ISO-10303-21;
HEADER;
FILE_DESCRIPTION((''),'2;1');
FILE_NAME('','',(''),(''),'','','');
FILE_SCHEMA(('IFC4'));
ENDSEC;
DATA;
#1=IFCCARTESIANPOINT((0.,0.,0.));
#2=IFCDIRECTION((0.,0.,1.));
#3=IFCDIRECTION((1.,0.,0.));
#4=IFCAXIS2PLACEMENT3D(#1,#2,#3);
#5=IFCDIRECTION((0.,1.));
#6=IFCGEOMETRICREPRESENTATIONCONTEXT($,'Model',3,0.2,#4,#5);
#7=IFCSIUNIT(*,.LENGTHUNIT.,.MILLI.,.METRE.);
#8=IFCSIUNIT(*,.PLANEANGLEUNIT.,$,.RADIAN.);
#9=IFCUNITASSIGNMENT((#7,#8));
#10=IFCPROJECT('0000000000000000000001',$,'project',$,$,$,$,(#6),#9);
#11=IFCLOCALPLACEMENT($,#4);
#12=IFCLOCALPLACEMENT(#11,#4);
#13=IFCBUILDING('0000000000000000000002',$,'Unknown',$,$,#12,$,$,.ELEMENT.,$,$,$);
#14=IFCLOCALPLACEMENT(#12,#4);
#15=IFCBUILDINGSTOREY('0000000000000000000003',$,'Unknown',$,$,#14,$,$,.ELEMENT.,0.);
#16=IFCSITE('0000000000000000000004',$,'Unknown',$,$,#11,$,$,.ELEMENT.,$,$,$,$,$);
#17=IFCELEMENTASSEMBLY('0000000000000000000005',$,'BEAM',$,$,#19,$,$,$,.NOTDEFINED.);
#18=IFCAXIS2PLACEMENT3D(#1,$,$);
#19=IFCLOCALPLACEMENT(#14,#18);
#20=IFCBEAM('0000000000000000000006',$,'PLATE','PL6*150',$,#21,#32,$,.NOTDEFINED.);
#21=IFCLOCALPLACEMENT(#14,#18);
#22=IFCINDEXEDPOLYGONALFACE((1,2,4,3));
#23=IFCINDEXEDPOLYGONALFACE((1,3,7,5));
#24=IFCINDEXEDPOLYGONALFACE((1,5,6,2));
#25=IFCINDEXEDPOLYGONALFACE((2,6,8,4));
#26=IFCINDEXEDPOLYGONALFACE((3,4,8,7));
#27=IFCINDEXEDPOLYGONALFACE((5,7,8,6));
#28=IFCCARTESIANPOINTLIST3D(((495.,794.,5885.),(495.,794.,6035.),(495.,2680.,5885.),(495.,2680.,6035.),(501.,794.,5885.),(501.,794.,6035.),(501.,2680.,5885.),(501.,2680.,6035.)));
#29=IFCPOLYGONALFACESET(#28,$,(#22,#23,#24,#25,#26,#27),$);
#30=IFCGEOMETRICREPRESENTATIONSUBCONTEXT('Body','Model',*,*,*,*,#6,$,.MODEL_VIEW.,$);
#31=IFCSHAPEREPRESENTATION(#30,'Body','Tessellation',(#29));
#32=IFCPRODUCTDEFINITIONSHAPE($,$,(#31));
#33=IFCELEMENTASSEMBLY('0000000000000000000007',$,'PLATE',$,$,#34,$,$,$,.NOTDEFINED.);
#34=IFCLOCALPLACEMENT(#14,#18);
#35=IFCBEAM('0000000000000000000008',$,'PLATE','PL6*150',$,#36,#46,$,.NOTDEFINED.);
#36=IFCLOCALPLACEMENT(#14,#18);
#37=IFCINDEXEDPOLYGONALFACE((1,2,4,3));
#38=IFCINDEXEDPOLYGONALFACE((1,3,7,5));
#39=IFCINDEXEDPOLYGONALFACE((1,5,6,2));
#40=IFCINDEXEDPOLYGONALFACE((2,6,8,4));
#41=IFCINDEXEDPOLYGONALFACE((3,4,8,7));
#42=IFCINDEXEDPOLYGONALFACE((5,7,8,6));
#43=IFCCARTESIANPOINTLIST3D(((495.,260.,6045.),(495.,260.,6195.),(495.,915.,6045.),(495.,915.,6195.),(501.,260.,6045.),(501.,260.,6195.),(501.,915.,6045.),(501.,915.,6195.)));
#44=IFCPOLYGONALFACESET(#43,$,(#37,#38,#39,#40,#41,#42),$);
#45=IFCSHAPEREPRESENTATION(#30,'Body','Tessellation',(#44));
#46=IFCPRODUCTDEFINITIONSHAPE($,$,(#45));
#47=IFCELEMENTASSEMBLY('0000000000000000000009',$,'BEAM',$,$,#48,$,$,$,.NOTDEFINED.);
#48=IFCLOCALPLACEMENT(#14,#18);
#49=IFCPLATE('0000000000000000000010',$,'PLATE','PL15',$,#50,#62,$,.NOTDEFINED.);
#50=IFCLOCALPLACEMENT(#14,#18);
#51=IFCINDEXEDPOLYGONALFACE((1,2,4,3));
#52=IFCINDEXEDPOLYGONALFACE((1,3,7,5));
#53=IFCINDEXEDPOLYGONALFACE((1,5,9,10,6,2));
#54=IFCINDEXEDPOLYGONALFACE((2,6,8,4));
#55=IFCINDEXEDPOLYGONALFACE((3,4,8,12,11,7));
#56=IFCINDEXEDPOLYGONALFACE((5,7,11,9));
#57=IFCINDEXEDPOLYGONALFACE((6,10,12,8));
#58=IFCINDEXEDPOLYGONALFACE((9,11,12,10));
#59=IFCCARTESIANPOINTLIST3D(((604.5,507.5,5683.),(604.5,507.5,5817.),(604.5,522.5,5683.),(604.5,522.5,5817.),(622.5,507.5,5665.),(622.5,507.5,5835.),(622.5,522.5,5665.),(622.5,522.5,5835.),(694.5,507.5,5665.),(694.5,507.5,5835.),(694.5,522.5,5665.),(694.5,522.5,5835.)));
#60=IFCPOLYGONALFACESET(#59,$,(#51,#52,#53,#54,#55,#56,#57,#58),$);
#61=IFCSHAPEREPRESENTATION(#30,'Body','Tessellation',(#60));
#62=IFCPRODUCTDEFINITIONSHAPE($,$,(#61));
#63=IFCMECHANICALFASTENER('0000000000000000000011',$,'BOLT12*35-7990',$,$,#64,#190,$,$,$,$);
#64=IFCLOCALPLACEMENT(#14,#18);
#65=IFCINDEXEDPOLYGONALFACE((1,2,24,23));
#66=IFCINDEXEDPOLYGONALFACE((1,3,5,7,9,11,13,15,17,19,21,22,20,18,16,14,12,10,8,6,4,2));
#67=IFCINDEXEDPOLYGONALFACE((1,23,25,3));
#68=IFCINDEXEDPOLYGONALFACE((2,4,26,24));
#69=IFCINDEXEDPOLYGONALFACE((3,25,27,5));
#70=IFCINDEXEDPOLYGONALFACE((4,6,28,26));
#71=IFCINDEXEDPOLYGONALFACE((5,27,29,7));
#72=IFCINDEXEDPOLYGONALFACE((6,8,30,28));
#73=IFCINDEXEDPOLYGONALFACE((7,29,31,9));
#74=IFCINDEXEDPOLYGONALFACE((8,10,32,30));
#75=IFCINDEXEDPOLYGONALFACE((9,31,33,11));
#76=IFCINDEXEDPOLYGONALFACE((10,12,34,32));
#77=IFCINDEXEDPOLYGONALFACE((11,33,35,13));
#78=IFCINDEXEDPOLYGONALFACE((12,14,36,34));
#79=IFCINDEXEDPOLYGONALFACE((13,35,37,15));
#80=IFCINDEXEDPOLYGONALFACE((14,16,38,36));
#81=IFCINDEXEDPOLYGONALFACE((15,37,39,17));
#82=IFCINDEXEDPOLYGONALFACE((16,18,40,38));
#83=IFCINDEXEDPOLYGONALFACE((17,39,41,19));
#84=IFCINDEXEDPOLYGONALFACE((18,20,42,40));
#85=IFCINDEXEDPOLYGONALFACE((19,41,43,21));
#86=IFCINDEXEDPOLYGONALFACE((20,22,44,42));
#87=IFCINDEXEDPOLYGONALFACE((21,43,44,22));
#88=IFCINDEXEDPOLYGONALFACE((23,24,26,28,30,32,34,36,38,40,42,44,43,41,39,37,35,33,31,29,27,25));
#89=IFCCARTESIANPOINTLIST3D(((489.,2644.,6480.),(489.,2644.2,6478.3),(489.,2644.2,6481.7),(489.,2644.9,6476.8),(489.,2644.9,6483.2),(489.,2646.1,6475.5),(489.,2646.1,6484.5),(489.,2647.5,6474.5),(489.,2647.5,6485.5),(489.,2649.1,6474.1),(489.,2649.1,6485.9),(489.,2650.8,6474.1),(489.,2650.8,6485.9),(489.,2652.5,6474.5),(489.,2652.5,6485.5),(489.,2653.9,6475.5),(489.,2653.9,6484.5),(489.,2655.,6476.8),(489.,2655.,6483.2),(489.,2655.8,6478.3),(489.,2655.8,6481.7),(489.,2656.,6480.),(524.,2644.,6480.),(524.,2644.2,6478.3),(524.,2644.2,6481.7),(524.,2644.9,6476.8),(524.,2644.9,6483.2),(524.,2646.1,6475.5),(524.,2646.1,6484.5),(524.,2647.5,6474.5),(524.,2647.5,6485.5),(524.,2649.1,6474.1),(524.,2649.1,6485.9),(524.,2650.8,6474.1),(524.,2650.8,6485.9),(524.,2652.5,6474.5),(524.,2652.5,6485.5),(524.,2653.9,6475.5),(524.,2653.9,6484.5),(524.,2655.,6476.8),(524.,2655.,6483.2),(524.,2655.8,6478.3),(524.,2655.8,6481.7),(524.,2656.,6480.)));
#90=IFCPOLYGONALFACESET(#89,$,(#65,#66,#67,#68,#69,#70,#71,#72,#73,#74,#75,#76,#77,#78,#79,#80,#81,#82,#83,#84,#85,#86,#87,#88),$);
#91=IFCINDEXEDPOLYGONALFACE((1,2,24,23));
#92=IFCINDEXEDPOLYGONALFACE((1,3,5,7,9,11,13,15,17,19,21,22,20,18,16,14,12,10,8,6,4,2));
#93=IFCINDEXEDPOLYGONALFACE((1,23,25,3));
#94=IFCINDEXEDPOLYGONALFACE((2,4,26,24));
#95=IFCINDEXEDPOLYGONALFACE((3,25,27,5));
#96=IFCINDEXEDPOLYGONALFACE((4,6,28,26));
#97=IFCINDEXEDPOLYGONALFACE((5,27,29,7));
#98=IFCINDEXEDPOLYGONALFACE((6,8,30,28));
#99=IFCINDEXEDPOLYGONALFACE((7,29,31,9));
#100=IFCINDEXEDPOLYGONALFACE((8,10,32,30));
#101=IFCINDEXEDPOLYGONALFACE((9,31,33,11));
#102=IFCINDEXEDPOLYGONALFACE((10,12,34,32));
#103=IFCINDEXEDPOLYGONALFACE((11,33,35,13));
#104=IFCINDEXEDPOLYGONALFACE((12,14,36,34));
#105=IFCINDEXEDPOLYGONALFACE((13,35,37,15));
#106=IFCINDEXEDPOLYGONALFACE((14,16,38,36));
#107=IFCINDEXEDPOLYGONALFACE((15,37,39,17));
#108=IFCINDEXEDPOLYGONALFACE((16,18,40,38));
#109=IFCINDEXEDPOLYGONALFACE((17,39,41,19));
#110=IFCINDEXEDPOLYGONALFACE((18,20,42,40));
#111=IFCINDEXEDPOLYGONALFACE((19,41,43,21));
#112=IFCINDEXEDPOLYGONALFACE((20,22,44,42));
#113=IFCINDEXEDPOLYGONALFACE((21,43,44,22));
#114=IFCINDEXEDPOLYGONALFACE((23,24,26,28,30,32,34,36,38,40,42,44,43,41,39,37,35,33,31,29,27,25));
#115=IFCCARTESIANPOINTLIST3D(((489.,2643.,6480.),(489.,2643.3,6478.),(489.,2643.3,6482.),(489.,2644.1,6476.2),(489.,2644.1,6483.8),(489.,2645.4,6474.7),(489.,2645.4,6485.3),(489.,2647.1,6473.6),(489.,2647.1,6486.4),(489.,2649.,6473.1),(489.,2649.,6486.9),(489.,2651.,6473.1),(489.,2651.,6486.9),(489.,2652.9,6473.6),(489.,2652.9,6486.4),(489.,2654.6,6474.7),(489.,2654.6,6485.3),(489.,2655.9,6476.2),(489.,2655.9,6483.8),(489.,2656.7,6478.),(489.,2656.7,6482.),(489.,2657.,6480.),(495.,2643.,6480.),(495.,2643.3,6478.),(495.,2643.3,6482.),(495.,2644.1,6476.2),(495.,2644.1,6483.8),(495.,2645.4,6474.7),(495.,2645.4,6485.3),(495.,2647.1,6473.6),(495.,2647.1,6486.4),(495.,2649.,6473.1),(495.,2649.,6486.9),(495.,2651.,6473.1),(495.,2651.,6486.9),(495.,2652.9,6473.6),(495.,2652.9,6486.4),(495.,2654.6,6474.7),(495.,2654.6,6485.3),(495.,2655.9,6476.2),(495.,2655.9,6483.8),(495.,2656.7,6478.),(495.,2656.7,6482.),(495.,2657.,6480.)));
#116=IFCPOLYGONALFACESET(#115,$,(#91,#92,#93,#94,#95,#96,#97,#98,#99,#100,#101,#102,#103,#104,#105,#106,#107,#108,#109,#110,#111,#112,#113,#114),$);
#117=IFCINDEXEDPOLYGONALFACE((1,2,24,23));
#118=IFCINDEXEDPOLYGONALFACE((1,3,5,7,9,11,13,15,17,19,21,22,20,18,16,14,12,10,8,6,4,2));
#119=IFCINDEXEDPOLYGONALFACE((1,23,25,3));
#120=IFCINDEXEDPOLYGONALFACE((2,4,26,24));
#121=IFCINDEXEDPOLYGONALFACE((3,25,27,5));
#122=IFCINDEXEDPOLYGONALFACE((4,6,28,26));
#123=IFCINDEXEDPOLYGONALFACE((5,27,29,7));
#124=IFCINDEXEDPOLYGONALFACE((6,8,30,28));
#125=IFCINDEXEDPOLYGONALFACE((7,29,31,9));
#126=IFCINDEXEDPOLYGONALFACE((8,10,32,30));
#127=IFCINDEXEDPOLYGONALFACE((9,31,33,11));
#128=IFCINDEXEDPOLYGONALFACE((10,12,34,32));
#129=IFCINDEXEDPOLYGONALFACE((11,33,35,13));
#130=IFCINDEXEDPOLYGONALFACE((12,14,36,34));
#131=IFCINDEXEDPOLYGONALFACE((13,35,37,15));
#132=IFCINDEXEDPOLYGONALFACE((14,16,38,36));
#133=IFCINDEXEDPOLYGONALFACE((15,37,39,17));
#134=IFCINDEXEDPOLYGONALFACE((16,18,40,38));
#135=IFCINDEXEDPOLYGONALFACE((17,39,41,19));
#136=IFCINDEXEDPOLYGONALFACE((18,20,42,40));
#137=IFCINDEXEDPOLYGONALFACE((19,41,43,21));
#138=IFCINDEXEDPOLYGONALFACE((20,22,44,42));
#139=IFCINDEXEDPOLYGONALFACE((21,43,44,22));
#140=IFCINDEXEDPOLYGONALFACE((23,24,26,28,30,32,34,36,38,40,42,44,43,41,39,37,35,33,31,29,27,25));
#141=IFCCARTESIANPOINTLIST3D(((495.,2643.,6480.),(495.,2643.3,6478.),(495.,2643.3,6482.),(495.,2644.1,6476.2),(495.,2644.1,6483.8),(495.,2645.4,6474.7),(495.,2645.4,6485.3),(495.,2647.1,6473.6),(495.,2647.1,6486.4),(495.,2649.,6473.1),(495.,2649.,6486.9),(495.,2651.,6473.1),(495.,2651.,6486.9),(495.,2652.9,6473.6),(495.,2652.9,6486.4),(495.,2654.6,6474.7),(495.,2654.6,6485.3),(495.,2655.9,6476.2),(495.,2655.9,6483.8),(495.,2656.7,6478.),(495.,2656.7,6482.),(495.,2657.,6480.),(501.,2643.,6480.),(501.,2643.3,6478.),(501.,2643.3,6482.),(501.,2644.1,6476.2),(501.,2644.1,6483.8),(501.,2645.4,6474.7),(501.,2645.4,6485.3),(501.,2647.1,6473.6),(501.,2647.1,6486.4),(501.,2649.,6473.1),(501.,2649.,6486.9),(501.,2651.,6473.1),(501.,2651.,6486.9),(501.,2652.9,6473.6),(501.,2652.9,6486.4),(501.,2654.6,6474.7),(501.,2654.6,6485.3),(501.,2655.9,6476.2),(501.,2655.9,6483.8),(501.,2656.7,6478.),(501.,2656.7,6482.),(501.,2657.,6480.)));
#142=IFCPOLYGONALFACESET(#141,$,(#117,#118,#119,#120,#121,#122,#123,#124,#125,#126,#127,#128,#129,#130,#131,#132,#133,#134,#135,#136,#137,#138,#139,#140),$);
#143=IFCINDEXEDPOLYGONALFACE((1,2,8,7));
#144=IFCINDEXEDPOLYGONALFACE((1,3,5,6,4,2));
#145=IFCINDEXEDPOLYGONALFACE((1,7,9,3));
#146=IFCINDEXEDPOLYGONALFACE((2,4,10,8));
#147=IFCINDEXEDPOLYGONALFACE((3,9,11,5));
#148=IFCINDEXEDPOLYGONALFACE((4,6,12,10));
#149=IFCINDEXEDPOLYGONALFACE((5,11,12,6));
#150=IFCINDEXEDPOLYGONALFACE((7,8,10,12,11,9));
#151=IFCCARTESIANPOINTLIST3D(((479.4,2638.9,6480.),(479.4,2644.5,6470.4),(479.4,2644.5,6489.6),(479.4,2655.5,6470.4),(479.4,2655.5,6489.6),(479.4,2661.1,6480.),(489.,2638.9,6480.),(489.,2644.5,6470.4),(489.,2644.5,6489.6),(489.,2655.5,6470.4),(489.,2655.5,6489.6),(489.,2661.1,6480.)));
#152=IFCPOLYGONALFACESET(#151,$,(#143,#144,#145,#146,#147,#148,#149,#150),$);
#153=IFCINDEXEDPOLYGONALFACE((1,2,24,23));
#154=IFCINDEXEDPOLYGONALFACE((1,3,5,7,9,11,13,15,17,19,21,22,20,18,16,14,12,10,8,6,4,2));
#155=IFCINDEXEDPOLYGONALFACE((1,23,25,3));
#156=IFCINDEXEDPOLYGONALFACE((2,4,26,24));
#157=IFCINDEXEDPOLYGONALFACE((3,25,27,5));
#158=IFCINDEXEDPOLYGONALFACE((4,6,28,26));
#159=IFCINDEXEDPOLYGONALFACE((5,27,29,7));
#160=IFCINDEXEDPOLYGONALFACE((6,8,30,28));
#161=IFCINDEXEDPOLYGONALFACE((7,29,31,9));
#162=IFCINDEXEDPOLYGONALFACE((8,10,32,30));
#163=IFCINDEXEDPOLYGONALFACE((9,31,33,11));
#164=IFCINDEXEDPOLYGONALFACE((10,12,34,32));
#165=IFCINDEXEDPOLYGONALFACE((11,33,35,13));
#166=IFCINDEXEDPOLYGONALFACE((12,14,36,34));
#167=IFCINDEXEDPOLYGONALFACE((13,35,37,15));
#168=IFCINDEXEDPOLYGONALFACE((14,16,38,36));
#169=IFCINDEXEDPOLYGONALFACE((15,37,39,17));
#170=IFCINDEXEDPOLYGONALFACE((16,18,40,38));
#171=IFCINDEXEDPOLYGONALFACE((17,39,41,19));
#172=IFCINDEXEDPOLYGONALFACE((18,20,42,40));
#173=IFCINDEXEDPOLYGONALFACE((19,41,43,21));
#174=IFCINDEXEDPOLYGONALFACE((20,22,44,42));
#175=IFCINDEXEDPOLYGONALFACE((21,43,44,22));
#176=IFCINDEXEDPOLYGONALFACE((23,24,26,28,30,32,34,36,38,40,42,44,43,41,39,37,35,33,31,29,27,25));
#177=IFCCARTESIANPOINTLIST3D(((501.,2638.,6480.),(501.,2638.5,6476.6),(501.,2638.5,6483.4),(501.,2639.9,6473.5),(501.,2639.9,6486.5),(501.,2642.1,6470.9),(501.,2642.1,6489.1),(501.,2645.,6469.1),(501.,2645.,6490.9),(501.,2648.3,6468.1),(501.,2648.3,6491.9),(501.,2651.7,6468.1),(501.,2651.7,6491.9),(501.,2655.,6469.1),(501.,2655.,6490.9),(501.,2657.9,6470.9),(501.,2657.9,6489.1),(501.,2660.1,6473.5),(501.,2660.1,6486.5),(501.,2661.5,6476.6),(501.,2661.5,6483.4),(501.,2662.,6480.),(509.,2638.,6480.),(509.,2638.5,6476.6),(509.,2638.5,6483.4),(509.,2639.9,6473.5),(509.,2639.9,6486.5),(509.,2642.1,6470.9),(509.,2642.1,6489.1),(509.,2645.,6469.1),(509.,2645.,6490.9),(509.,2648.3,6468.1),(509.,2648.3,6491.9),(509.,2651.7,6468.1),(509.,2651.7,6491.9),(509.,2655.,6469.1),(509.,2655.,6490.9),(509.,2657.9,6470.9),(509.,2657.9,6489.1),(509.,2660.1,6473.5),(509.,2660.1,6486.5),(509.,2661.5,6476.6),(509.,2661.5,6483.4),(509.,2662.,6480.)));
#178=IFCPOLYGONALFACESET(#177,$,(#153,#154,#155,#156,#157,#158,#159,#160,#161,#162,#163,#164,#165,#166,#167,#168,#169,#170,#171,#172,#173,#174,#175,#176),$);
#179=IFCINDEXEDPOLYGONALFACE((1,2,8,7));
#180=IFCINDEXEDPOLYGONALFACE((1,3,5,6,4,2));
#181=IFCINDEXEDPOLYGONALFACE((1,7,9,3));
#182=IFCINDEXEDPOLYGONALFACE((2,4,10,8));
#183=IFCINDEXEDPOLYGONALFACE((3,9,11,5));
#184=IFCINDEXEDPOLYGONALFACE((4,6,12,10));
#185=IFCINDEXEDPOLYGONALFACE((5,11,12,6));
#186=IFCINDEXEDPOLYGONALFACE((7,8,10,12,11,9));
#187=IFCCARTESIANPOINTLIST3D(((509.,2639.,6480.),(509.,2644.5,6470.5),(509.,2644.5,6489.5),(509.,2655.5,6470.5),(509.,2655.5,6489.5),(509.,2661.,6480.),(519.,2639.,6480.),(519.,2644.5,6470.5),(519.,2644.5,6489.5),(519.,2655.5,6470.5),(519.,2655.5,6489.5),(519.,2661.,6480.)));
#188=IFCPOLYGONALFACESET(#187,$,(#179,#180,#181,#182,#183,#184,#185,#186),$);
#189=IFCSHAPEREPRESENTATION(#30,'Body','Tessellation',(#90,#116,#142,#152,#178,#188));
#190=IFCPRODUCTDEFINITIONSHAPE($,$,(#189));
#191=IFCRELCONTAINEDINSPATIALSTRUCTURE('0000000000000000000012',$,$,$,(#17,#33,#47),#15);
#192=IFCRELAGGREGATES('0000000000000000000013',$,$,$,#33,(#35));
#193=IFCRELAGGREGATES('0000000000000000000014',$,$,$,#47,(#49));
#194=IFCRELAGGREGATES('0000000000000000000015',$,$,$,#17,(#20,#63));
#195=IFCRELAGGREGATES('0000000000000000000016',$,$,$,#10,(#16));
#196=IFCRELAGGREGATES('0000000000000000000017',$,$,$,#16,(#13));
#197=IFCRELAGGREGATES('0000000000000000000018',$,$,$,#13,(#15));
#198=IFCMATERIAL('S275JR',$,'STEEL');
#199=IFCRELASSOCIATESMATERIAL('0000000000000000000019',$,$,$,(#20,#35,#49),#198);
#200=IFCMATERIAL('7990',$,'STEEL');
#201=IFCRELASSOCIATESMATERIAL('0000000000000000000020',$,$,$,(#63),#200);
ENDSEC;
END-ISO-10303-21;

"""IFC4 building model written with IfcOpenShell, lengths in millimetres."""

from ifc_helpers import new_model, si_unit, direction, frame, origin_with_axes, place, context, subcontext, project, spatial, line, arc, indexed_curve, outline, extrude, source, transform, mapped, material, element, aggregate, save


model = new_model("IFC4")

# Units and contexts
model_context = context("Model", 3, precision=0.2, world=origin_with_axes(), true_north=direction((0.0, 1.0)))
body_context = subcontext(model_context, "Body", "Model", "MODEL_VIEW")
ifc_project = project(units=[si_unit("LENGTHUNIT", "METRE", prefix="MILLI"), si_unit("PLANEANGLEUNIT", "RADIAN")], contexts=[model_context])

# Site, building, storey
site_placement = place(None, origin_with_axes())
site = spatial("IfcSite", under=ifc_project, at=site_placement, Name="Unknown", CompositionType="ELEMENT")
building_placement = place(site_placement, origin_with_axes())
building = spatial("IfcBuilding", under=site, at=building_placement, Name="Unknown", CompositionType="ELEMENT")
storey_placement = place(building_placement, origin_with_axes())
storey = spatial("IfcBuildingStorey", under=building, at=storey_placement, Name="Unknown", CompositionType="ELEMENT", Elevation=0.0)

# Element assembly
assembly_1_placement = place(storey_placement, frame((495.0, 2670.0, 6980.0), z_axis=(-1.0, 0.0, 0.0), x_axis=(0.0, -1.0, 0.000002)))
assembly_1 = element("IfcElementAssembly", 1, at=assembly_1_placement, inside=storey, Name="BEAM", PredefinedType="NOTDEFINED")
ifc_material_1 = material(Name="S275JR", Category="STEEL")

# Beam
beam_1_placement = place(assembly_1_placement, frame((-10.0, -1020.0, -3.0), z_axis=(0.0, 0.0, 1.0), x_axis=(1.0, 0.0, 0.0)))
beam_1 = element("IfcBeam", 2, at=beam_1_placement, material=ifc_material_1, Name="PLATE", Description="PL6*150", PredefinedType="NOTDEFINED", context=body_context, shape_type="SolidModel", body=[
    extrude(outline(indexed_curve([(-3.0, -75.0), (3.0, -75.0), (3.0, 75.0), (-3.0, 75.0)], segments=[line(1, 2, 3, 4, 1)])), frame((0.0, 0.0, 0.0), z_axis=(-1.0, 0.0, 0.0), x_axis=(0.0, 0.0, 1.0)), (0.0, -0.000002, -1.0), 1886.0),
])

# Element assembly, beam
assembly_2_placement = place(storey_placement, frame((498.0, 915.0, 6120.0), z_axis=(-1.0, 0.0, 0.0), x_axis=(0.0, -1.0, 0.000002)))
assembly_2 = element("IfcElementAssembly", 3, at=assembly_2_placement, inside=storey, Name="PLATE", PredefinedType="NOTDEFINED")
beam_2_placement = place(assembly_2_placement, origin_with_axes())
beam_2 = element("IfcBeam", 4, at=beam_2_placement, material=ifc_material_1, Name="PLATE", Description="PL6*150", PredefinedType="NOTDEFINED", context=body_context, shape_type="SolidModel", body=[
    extrude(outline(indexed_curve([(-3.0, -75.0), (3.0, -75.0), (3.0, 75.0), (-3.0, 75.0)], segments=[line(1, 2, 3, 4, 1)])), frame((0.0, 0.0, 0.0), z_axis=(-1.0, 0.0, 0.0), x_axis=(0.0, 0.0, 1.0)), (0.0, -0.000002, -1.0), 655.0),
])
aggregate(assembly_2, [beam_2])

# Element assembly, plate
assembly_3_placement = place(storey_placement, frame((600.0, 0.0, 5750.0), z_axis=(1.0, 0.0, 0.0), x_axis=(0.0, 1.0, 0.0)))
assembly_3 = element("IfcElementAssembly", 5, at=assembly_3_placement, inside=storey, Name="BEAM", PredefinedType="NOTDEFINED")
plate_1_placement = place(assembly_3_placement, frame((515.0, -85.0, 4.5), z_axis=(-1.0, 0.0, 0.0), x_axis=(0.0, 0.0, 1.0)))
plate_1 = element("IfcPlate", 6, at=plate_1_placement, material=ifc_material_1, Name="PLATE", Description="PL15", PredefinedType="NOTDEFINED", context=body_context, shape_type="SolidModel", body=[
    extrude(outline(indexed_curve([(0.0, 18.0), (18.0, 0.0), (90.0, 0.0), (90.0, 170.0), (18.0, 170.0), (0.0, 152.0)], segments=[line(1, 2, 3, 4, 5, 6, 1)])), frame((0.0, 0.0, 7.5), z_axis=(0.0, 0.0, 1.0), x_axis=(1.0, 0.0, 0.0)), (0.0, -0.000002, -1.0), 15.0),
])
aggregate(assembly_3, [plate_1])

# Mechanical fastener
ifc_material_2 = material(Name="7990", Category="STEEL")
shared_shape_1 = source(origin_with_axes(), body_context, "Body", "SweptSolid", [
    extrude(outline(indexed_curve([(6.0, 0.0), (0.0, 6.0), (-6.0, 0.0), (0.0, -6.0)], segments=[arc(1, 2, 3), arc(3, 4, 1)])), frame((0.0, 0.0, 6.0), z_axis=(0.0, -0.000002, -1.0), x_axis=(0.0, 1.0, 0.0)), (0.0, 0.0, 1.0), 35.0),
    extrude(outline(indexed_curve([(7.0, 0.0), (0.0, 7.0), (-7.0, 0.0), (0.0, -7.0)], segments=[arc(1, 2, 3), arc(3, 4, 1)])), frame((0.0, 0.0, 6.0), z_axis=(0.0, -0.000002, -1.0), x_axis=(0.0, 1.0, 0.0)), (0.0, 0.0, 1.0), 6.0),
    extrude(outline(indexed_curve([(7.0, 0.0), (0.0, 7.0), (-7.0, 0.0), (0.0, -7.0)], segments=[arc(1, 2, 3), arc(3, 4, 1)])), frame((0.0, 0.0, 0.0), z_axis=(0.0, -0.000002, -1.0), x_axis=(0.0, 1.0, 0.0)), (0.0, 0.0, 1.0), 6.0),
    extrude(outline(indexed_curve([(11.1, 0.0), (5.5, 9.6), (-5.5, 9.6), (-11.1, 0.0), (-5.5, -9.6), (5.5, -9.6)], segments=[line(1, 2, 3, 4, 5, 6, 1)])), frame((0.0, 0.0, 15.6), z_axis=(0.0, -0.000002, -1.0), x_axis=(0.0, 1.0, 0.0)), (0.0, 0.0, 1.0), 9.6),
    extrude(outline(indexed_curve([(12.0, 0.0), (0.0, 12.0), (-12.0, 0.0), (0.0, -12.0)], segments=[arc(1, 2, 3), arc(3, 4, 1)])), frame((0.0, 0.0, -6.0), z_axis=(0.0, -0.000002, -1.0), x_axis=(0.0, 1.0, 0.0)), (0.0, 0.0, 1.0), 8.0),
    extrude(outline(indexed_curve([(11.0, 0.0), (5.5, 9.5), (-5.5, 9.5), (-11.0, 0.0), (-5.5, -9.5), (5.5, -9.5)], segments=[line(1, 2, 3, 4, 5, 6, 1)])), frame((0.0, 0.0, -14.0), z_axis=(0.0, -0.000002, -1.0), x_axis=(0.0, 1.0, 0.0)), (0.0, 0.0, 1.0), 10.0),
])
mechanical_fastener_1_placement = place(assembly_1_placement, frame((20.0, -500.0, 0.0), z_axis=(0.0, 0.0, 1.0), x_axis=(0.0, -1.0, 0.000002)))
mechanical_fastener_1 = element("IfcMechanicalFastener", 7, at=mechanical_fastener_1_placement, material=ifc_material_2, Name="BOLT12*35-7990", context=body_context, shape_type="MappedRepresentation", body=[
    mapped(shared_shape_1, transform((0.0, 0.0, 0.0))),
])
aggregate(assembly_1, [beam_1, mechanical_fastener_1])

save(model, "model.ifc")
